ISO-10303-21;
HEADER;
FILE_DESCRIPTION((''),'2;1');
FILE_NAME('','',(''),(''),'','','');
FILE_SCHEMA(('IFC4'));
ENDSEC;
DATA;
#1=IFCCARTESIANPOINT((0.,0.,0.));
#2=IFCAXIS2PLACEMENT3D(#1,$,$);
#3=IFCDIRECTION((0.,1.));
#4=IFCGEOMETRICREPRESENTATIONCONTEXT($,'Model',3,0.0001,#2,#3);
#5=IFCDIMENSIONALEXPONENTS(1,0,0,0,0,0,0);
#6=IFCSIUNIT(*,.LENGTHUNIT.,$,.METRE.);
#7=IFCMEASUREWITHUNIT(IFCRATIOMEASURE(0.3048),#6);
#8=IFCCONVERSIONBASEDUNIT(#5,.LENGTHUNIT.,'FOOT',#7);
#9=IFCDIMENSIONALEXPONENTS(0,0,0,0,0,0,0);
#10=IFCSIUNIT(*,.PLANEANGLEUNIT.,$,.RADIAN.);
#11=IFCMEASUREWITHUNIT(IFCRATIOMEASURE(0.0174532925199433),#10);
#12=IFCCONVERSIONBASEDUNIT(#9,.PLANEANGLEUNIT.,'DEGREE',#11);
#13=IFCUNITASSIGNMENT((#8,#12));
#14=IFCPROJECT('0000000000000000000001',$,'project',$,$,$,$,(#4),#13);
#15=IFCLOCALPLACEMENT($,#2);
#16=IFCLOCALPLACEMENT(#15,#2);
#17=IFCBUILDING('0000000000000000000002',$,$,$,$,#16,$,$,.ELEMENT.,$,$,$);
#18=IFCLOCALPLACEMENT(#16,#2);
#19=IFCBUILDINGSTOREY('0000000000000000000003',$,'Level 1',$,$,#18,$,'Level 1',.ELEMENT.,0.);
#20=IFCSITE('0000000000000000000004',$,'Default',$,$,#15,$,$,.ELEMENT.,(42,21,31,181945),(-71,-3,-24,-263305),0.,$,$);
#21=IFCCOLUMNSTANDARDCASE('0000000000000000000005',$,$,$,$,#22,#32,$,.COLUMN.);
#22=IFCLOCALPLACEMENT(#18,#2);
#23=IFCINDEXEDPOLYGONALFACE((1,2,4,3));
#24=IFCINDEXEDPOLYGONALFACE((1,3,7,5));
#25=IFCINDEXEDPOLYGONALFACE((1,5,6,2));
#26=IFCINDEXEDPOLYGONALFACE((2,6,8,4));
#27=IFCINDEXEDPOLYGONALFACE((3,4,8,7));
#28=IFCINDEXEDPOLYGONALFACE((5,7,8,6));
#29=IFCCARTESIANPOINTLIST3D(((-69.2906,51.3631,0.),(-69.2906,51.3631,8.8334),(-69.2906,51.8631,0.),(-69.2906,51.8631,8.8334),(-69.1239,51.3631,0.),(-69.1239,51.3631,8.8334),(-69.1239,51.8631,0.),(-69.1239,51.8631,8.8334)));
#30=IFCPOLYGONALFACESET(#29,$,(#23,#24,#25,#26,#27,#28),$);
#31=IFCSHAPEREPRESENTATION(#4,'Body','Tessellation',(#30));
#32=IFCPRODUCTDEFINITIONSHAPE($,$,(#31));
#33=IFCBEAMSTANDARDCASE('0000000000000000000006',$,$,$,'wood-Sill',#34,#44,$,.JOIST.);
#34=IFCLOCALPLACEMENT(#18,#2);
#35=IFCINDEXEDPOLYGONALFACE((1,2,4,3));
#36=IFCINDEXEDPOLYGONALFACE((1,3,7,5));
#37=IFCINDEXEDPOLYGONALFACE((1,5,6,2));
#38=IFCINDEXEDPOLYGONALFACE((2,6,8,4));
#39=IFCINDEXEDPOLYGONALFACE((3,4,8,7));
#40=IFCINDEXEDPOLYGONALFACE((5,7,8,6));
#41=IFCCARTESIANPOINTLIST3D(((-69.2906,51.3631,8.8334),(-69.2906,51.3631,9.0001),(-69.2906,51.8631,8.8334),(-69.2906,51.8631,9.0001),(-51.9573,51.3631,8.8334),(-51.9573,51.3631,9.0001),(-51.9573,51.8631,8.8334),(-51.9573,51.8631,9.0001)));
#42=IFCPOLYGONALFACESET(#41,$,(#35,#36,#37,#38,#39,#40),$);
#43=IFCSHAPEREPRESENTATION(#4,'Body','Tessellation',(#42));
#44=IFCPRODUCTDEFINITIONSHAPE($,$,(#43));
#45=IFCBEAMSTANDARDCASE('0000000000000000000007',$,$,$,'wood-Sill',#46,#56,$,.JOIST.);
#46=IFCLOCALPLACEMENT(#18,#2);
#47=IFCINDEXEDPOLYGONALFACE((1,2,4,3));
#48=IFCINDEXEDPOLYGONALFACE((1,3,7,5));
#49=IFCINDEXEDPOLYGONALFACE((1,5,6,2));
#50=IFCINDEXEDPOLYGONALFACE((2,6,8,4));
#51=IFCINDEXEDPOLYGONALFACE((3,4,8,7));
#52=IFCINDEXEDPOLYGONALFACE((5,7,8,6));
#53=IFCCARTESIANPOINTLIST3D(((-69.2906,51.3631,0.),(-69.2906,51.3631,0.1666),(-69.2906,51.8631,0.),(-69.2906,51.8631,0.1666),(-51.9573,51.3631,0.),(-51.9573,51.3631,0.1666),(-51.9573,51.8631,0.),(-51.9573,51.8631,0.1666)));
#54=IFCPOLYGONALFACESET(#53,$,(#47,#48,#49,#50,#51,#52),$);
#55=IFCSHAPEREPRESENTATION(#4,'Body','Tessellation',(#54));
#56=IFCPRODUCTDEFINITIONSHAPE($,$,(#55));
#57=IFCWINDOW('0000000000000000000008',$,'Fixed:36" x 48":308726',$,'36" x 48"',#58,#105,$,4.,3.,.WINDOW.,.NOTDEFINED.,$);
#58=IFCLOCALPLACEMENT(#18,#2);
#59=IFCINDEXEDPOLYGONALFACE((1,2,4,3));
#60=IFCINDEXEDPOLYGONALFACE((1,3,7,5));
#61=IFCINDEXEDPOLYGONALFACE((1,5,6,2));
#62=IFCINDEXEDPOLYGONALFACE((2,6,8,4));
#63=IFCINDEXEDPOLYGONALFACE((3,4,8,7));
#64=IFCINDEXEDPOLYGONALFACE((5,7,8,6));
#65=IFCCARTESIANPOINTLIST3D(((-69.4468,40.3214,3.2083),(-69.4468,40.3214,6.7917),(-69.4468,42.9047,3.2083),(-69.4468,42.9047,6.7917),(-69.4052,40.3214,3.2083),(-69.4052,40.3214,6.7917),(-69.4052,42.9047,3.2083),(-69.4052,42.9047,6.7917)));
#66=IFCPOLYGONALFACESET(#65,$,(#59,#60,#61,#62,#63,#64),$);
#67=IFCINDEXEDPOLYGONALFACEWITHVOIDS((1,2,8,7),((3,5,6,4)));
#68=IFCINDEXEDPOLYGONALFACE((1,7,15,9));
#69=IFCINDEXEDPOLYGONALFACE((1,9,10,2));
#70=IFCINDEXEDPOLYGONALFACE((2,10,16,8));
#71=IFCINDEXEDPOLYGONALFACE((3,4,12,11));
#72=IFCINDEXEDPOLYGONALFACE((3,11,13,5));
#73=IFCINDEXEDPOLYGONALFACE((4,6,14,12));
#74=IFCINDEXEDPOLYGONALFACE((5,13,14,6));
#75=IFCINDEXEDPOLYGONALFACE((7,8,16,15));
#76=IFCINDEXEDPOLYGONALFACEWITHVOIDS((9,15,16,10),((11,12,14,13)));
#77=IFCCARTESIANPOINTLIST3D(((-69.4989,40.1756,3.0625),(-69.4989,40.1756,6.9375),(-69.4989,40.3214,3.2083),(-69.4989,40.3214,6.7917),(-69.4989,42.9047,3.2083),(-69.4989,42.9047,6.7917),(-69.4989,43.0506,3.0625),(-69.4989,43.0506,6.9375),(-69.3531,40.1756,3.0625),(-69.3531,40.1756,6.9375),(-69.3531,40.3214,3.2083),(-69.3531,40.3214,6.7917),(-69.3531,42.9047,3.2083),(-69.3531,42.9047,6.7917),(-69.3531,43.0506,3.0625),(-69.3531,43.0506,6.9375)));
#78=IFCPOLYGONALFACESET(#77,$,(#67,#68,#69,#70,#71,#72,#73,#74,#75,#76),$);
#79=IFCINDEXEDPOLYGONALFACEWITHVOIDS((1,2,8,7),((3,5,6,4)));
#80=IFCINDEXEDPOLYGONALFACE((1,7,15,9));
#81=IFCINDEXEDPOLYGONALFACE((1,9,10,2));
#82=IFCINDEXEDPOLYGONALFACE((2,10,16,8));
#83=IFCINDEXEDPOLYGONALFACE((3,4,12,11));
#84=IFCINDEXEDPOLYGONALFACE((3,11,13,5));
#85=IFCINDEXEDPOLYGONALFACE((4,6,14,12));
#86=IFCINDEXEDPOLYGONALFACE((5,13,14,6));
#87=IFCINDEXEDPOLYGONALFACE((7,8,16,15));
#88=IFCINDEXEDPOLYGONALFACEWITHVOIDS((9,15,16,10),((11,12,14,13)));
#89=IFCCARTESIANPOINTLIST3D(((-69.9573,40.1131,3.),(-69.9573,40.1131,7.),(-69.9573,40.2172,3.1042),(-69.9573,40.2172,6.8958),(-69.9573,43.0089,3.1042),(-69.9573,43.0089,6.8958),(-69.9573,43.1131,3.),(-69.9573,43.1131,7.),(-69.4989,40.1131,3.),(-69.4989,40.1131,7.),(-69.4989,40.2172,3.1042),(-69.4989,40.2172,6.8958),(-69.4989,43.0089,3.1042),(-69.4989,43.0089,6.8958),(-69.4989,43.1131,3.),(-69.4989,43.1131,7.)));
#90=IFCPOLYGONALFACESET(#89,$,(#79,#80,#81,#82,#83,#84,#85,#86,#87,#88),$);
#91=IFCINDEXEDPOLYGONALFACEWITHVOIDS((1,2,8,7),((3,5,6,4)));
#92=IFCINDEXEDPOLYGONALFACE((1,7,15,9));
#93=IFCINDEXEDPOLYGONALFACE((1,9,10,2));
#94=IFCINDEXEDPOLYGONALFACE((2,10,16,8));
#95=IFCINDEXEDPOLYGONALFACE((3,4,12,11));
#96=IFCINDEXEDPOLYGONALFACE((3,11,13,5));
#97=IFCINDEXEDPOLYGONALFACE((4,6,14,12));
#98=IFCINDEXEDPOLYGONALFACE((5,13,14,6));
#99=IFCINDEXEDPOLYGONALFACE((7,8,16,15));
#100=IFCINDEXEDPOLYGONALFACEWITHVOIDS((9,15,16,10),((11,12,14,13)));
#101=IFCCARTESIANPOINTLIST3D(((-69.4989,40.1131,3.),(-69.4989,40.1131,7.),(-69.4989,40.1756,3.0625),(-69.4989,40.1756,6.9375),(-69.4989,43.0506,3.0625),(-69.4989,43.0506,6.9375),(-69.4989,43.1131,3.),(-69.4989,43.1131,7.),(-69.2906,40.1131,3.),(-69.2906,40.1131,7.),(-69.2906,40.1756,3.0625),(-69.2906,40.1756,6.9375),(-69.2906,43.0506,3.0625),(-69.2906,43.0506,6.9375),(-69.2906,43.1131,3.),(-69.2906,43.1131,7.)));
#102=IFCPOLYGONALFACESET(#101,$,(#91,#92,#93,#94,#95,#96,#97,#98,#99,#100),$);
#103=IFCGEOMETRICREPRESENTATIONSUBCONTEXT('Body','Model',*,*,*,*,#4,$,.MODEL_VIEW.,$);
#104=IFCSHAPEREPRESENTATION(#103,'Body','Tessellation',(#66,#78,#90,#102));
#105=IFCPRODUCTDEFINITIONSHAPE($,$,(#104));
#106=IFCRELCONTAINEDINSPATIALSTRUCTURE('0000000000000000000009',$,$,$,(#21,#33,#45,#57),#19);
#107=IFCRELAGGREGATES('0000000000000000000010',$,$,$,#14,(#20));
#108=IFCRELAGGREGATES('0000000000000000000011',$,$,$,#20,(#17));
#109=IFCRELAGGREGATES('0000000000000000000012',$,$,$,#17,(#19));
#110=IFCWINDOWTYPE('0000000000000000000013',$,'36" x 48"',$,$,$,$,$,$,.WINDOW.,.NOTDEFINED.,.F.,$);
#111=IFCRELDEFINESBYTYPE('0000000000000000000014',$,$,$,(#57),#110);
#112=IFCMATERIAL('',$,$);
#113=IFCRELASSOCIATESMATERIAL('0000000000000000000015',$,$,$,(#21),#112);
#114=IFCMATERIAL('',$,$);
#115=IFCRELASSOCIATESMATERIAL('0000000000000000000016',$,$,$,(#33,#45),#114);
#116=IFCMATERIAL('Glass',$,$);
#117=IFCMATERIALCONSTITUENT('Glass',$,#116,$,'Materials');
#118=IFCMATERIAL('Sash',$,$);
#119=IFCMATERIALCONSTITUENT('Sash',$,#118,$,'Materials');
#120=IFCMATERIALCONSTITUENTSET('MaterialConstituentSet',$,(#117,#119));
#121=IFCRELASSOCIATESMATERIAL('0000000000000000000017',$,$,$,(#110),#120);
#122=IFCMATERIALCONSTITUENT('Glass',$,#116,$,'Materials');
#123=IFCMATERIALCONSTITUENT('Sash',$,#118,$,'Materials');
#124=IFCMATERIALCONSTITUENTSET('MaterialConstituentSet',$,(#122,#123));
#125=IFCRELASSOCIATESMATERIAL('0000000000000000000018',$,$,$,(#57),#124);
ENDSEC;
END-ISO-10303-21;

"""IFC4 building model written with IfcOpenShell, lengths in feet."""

from ifc_helpers import new_model, entity, si_unit, converted_unit, direction, frame, frame_2d, origin, origin_with_axes, place, context, subcontext, project, spatial, polyline, rectangle, outline, extrude, source, transform, mapped, material, constituent, constituent_set, type_object, type_shapes, element, save


model = new_model("IFC4")

# Units and contexts
model_context = context("Model", 3, precision=0.0001, world=origin(), true_north=direction((0.0, 1.0)))
body_context = subcontext(model_context, "Body", "Model", "MODEL_VIEW")
ifc_project = project(units=[converted_unit("LENGTHUNIT", "FOOT", entity("IfcRatioMeasure", 0.3048), si_unit("LENGTHUNIT", "METRE"), dimensions=[1, 0, 0, 0, 0, 0, 0]), converted_unit("PLANEANGLEUNIT", "DEGREE", entity("IfcRatioMeasure", 0.0174532925199433), si_unit("PLANEANGLEUNIT", "RADIAN"), dimensions=[0, 0, 0, 0, 0, 0, 0])], contexts=[model_context])

# Site, building, storey
site_placement = place(None, origin())
site = spatial("IfcSite", under=ifc_project, at=site_placement, Name="Default", CompositionType="ELEMENT", RefLatitude=(42, 21, 31, 181945), RefLongitude=(-71, -3, -24, -263305), RefElevation=0.0)
building_placement = place(site_placement, origin())
building = spatial("IfcBuilding", under=site, at=building_placement, CompositionType="ELEMENT")
storey_placement = place(building_placement, origin())
storey = spatial("IfcBuildingStorey", under=building, at=storey_placement, Name="Level 1", LongName="Level 1", CompositionType="ELEMENT", Elevation=0.0)

# Column
placement_1 = place(storey_placement, frame((-69.6239, 19.7797, 0.0), z_axis=(0.0, 0.0, 1.0), x_axis=(0.0, 1.0, 0.0)))
ifc_material_1 = material(Name="")
placement_2 = place(storey_placement, frame((-69.2906, 51.6131, 0.0)))
for number, where, z_axis, x_axis in (
    (1, (0.0833, 0.0, 0.0), (0.0, 0.0, 1.0), (1.0, 0.0, 0.0)),
):
    element("IfcColumnStandardCase", number, at=place(placement_2, frame(where, z_axis=z_axis, x_axis=x_axis)), inside=storey, material=ifc_material_1, PredefinedType="COLUMN", context=model_context, shape_type="SweptSolid", body=[
        extrude(rectangle(XDim=0.1667, YDim=0.5), origin(), (0.0, 0.0, 1.0), 8.8334),
    ])

# Beams
ifc_material_2 = material(Name="")
for number, where, z_axis, x_axis in (
    (2, (0.0, 0.0, 8.9167), (1.0, 0.0, 0.0), (0.0, 0.0, 1.0)),
    (3, (0.0, 0.0, 0.0833), (1.0, 0.0, 0.0), (0.0, 0.0, 1.0)),
):
    element("IfcBeamStandardCase", number, at=place(placement_2, frame(where, z_axis=z_axis, x_axis=x_axis)), inside=storey, material=ifc_material_2, ObjectType="wood-Sill", PredefinedType="JOIST", context=model_context, shape_type="SweptSolid", body=[
        extrude(rectangle(XDim=0.1667, YDim=0.5), origin_with_axes(), (0.0, 0.0, 1.0), 17.3333),
    ])

# Window
ifc_material_3 = material(Name="Glass")
ifc_constituent_1 = constituent(ifc_material_3, Name="Glass", Category="Materials")
ifc_material_4 = material(Name="Sash")
ifc_constituent_2 = constituent(ifc_material_4, Name="Sash", Category="Materials")
ifc_constituent_set_1 = constituent_set(constituents=[ifc_constituent_1, ifc_constituent_2], Name="MaterialConstituentSet")
ifc_constituent_3 = constituent(ifc_material_3, Name="Glass", Category="Materials")
ifc_constituent_4 = constituent(ifc_material_4, Name="Sash", Category="Materials")
ifc_constituent_set_2 = constituent_set(constituents=[ifc_constituent_3, ifc_constituent_4], Name="MaterialConstituentSet")
window_type = type_object("IfcWindowType", Name="36\" x 48\"", ParameterTakesPrecedence=False, PartitioningType="NOTDEFINED", PredefinedType="WINDOW", material=ifc_constituent_set_2)
shared_shape = source(origin(), body_context, "Body", "SweptSolid", [
    extrude(rectangle(XDim=0.0417, YDim=2.5833, at=frame_2d((0.0, 0.0), x_axis=(1.0, 0.0))), frame((1.5, 0.5312, 0.2083), z_axis=(0.0, 0.0, 1.0), x_axis=(0.0, 1.0, 0.0)), (0.0, 0.0, 1.0), 3.5833),
    extrude(outline(polyline([(-1.4375, -1.9375), (1.4375, -1.9375), (1.4375, 1.9375), (-1.4375, 1.9375), (-1.4375, -1.9375)]), holes=[polyline([(-1.2917, -1.7917), (-1.2917, 1.7917), (1.2917, 1.7917), (1.2917, -1.7917), (-1.2917, -1.7917)])]), frame((1.5, 0.4583, 2.0), z_axis=(0.0, 1.0, 0.0), x_axis=(1.0, 0.0, 0.0)), (0.0, 0.0, 1.0), 0.1458),
    extrude(outline(polyline([(-1.5, -2.0), (1.5, -2.0), (1.5, 2.0), (-1.5, 2.0), (-1.5, -2.0)]), holes=[polyline([(-1.3958, -1.8958), (-1.3958, 1.8958), (1.3958, 1.8958), (1.3958, -1.8958), (-1.3958, -1.8958)])]), frame((1.5, 0.0, 2.0), z_axis=(0.0, 1.0, 0.0), x_axis=(1.0, 0.0, 0.0)), (0.0, 0.0, 1.0), 0.4583),
    extrude(outline(polyline([(-2.0, -1.5), (2.0, -1.5), (2.0, 1.5), (-2.0, 1.5), (-2.0, -1.5)]), holes=[polyline([(-1.9375, -1.4375), (-1.9375, 1.4375), (1.9375, 1.4375), (1.9375, -1.4375), (-1.9375, -1.4375)])]), frame((1.5, 0.4583, 2.0), z_axis=(0.0, 1.0, 0.0), x_axis=(0.0, 0.0, -1.0)), (0.0, 0.0, 1.0), 0.2083),
])
type_shapes(window_type, [shared_shape])
placement_3 = place(placement_1, frame((23.3333, 0.3333, 3.0)))
window_placement = place(placement_3, frame((0.0, 0.0, 0.0), z_axis=(0.0, 0.0, 1.0), x_axis=(-1.0, 0.0, 0.0)))
element("IfcWindow", 4, at=window_placement, inside=storey, type_object=window_type, material=ifc_constituent_set_1, Name="Fixed:36\" x 48\":308726", ObjectType="36\" x 48\"", OverallHeight=4.0, OverallWidth=3.0, PartitioningType="NOTDEFINED", PredefinedType="WINDOW", context=body_context, shape_type="MappedRepresentation", body=[
    mapped(shared_shape, transform((0.0, 0.0, 0.0), scale=1.0)),
])

save(model, "model.ifc")
